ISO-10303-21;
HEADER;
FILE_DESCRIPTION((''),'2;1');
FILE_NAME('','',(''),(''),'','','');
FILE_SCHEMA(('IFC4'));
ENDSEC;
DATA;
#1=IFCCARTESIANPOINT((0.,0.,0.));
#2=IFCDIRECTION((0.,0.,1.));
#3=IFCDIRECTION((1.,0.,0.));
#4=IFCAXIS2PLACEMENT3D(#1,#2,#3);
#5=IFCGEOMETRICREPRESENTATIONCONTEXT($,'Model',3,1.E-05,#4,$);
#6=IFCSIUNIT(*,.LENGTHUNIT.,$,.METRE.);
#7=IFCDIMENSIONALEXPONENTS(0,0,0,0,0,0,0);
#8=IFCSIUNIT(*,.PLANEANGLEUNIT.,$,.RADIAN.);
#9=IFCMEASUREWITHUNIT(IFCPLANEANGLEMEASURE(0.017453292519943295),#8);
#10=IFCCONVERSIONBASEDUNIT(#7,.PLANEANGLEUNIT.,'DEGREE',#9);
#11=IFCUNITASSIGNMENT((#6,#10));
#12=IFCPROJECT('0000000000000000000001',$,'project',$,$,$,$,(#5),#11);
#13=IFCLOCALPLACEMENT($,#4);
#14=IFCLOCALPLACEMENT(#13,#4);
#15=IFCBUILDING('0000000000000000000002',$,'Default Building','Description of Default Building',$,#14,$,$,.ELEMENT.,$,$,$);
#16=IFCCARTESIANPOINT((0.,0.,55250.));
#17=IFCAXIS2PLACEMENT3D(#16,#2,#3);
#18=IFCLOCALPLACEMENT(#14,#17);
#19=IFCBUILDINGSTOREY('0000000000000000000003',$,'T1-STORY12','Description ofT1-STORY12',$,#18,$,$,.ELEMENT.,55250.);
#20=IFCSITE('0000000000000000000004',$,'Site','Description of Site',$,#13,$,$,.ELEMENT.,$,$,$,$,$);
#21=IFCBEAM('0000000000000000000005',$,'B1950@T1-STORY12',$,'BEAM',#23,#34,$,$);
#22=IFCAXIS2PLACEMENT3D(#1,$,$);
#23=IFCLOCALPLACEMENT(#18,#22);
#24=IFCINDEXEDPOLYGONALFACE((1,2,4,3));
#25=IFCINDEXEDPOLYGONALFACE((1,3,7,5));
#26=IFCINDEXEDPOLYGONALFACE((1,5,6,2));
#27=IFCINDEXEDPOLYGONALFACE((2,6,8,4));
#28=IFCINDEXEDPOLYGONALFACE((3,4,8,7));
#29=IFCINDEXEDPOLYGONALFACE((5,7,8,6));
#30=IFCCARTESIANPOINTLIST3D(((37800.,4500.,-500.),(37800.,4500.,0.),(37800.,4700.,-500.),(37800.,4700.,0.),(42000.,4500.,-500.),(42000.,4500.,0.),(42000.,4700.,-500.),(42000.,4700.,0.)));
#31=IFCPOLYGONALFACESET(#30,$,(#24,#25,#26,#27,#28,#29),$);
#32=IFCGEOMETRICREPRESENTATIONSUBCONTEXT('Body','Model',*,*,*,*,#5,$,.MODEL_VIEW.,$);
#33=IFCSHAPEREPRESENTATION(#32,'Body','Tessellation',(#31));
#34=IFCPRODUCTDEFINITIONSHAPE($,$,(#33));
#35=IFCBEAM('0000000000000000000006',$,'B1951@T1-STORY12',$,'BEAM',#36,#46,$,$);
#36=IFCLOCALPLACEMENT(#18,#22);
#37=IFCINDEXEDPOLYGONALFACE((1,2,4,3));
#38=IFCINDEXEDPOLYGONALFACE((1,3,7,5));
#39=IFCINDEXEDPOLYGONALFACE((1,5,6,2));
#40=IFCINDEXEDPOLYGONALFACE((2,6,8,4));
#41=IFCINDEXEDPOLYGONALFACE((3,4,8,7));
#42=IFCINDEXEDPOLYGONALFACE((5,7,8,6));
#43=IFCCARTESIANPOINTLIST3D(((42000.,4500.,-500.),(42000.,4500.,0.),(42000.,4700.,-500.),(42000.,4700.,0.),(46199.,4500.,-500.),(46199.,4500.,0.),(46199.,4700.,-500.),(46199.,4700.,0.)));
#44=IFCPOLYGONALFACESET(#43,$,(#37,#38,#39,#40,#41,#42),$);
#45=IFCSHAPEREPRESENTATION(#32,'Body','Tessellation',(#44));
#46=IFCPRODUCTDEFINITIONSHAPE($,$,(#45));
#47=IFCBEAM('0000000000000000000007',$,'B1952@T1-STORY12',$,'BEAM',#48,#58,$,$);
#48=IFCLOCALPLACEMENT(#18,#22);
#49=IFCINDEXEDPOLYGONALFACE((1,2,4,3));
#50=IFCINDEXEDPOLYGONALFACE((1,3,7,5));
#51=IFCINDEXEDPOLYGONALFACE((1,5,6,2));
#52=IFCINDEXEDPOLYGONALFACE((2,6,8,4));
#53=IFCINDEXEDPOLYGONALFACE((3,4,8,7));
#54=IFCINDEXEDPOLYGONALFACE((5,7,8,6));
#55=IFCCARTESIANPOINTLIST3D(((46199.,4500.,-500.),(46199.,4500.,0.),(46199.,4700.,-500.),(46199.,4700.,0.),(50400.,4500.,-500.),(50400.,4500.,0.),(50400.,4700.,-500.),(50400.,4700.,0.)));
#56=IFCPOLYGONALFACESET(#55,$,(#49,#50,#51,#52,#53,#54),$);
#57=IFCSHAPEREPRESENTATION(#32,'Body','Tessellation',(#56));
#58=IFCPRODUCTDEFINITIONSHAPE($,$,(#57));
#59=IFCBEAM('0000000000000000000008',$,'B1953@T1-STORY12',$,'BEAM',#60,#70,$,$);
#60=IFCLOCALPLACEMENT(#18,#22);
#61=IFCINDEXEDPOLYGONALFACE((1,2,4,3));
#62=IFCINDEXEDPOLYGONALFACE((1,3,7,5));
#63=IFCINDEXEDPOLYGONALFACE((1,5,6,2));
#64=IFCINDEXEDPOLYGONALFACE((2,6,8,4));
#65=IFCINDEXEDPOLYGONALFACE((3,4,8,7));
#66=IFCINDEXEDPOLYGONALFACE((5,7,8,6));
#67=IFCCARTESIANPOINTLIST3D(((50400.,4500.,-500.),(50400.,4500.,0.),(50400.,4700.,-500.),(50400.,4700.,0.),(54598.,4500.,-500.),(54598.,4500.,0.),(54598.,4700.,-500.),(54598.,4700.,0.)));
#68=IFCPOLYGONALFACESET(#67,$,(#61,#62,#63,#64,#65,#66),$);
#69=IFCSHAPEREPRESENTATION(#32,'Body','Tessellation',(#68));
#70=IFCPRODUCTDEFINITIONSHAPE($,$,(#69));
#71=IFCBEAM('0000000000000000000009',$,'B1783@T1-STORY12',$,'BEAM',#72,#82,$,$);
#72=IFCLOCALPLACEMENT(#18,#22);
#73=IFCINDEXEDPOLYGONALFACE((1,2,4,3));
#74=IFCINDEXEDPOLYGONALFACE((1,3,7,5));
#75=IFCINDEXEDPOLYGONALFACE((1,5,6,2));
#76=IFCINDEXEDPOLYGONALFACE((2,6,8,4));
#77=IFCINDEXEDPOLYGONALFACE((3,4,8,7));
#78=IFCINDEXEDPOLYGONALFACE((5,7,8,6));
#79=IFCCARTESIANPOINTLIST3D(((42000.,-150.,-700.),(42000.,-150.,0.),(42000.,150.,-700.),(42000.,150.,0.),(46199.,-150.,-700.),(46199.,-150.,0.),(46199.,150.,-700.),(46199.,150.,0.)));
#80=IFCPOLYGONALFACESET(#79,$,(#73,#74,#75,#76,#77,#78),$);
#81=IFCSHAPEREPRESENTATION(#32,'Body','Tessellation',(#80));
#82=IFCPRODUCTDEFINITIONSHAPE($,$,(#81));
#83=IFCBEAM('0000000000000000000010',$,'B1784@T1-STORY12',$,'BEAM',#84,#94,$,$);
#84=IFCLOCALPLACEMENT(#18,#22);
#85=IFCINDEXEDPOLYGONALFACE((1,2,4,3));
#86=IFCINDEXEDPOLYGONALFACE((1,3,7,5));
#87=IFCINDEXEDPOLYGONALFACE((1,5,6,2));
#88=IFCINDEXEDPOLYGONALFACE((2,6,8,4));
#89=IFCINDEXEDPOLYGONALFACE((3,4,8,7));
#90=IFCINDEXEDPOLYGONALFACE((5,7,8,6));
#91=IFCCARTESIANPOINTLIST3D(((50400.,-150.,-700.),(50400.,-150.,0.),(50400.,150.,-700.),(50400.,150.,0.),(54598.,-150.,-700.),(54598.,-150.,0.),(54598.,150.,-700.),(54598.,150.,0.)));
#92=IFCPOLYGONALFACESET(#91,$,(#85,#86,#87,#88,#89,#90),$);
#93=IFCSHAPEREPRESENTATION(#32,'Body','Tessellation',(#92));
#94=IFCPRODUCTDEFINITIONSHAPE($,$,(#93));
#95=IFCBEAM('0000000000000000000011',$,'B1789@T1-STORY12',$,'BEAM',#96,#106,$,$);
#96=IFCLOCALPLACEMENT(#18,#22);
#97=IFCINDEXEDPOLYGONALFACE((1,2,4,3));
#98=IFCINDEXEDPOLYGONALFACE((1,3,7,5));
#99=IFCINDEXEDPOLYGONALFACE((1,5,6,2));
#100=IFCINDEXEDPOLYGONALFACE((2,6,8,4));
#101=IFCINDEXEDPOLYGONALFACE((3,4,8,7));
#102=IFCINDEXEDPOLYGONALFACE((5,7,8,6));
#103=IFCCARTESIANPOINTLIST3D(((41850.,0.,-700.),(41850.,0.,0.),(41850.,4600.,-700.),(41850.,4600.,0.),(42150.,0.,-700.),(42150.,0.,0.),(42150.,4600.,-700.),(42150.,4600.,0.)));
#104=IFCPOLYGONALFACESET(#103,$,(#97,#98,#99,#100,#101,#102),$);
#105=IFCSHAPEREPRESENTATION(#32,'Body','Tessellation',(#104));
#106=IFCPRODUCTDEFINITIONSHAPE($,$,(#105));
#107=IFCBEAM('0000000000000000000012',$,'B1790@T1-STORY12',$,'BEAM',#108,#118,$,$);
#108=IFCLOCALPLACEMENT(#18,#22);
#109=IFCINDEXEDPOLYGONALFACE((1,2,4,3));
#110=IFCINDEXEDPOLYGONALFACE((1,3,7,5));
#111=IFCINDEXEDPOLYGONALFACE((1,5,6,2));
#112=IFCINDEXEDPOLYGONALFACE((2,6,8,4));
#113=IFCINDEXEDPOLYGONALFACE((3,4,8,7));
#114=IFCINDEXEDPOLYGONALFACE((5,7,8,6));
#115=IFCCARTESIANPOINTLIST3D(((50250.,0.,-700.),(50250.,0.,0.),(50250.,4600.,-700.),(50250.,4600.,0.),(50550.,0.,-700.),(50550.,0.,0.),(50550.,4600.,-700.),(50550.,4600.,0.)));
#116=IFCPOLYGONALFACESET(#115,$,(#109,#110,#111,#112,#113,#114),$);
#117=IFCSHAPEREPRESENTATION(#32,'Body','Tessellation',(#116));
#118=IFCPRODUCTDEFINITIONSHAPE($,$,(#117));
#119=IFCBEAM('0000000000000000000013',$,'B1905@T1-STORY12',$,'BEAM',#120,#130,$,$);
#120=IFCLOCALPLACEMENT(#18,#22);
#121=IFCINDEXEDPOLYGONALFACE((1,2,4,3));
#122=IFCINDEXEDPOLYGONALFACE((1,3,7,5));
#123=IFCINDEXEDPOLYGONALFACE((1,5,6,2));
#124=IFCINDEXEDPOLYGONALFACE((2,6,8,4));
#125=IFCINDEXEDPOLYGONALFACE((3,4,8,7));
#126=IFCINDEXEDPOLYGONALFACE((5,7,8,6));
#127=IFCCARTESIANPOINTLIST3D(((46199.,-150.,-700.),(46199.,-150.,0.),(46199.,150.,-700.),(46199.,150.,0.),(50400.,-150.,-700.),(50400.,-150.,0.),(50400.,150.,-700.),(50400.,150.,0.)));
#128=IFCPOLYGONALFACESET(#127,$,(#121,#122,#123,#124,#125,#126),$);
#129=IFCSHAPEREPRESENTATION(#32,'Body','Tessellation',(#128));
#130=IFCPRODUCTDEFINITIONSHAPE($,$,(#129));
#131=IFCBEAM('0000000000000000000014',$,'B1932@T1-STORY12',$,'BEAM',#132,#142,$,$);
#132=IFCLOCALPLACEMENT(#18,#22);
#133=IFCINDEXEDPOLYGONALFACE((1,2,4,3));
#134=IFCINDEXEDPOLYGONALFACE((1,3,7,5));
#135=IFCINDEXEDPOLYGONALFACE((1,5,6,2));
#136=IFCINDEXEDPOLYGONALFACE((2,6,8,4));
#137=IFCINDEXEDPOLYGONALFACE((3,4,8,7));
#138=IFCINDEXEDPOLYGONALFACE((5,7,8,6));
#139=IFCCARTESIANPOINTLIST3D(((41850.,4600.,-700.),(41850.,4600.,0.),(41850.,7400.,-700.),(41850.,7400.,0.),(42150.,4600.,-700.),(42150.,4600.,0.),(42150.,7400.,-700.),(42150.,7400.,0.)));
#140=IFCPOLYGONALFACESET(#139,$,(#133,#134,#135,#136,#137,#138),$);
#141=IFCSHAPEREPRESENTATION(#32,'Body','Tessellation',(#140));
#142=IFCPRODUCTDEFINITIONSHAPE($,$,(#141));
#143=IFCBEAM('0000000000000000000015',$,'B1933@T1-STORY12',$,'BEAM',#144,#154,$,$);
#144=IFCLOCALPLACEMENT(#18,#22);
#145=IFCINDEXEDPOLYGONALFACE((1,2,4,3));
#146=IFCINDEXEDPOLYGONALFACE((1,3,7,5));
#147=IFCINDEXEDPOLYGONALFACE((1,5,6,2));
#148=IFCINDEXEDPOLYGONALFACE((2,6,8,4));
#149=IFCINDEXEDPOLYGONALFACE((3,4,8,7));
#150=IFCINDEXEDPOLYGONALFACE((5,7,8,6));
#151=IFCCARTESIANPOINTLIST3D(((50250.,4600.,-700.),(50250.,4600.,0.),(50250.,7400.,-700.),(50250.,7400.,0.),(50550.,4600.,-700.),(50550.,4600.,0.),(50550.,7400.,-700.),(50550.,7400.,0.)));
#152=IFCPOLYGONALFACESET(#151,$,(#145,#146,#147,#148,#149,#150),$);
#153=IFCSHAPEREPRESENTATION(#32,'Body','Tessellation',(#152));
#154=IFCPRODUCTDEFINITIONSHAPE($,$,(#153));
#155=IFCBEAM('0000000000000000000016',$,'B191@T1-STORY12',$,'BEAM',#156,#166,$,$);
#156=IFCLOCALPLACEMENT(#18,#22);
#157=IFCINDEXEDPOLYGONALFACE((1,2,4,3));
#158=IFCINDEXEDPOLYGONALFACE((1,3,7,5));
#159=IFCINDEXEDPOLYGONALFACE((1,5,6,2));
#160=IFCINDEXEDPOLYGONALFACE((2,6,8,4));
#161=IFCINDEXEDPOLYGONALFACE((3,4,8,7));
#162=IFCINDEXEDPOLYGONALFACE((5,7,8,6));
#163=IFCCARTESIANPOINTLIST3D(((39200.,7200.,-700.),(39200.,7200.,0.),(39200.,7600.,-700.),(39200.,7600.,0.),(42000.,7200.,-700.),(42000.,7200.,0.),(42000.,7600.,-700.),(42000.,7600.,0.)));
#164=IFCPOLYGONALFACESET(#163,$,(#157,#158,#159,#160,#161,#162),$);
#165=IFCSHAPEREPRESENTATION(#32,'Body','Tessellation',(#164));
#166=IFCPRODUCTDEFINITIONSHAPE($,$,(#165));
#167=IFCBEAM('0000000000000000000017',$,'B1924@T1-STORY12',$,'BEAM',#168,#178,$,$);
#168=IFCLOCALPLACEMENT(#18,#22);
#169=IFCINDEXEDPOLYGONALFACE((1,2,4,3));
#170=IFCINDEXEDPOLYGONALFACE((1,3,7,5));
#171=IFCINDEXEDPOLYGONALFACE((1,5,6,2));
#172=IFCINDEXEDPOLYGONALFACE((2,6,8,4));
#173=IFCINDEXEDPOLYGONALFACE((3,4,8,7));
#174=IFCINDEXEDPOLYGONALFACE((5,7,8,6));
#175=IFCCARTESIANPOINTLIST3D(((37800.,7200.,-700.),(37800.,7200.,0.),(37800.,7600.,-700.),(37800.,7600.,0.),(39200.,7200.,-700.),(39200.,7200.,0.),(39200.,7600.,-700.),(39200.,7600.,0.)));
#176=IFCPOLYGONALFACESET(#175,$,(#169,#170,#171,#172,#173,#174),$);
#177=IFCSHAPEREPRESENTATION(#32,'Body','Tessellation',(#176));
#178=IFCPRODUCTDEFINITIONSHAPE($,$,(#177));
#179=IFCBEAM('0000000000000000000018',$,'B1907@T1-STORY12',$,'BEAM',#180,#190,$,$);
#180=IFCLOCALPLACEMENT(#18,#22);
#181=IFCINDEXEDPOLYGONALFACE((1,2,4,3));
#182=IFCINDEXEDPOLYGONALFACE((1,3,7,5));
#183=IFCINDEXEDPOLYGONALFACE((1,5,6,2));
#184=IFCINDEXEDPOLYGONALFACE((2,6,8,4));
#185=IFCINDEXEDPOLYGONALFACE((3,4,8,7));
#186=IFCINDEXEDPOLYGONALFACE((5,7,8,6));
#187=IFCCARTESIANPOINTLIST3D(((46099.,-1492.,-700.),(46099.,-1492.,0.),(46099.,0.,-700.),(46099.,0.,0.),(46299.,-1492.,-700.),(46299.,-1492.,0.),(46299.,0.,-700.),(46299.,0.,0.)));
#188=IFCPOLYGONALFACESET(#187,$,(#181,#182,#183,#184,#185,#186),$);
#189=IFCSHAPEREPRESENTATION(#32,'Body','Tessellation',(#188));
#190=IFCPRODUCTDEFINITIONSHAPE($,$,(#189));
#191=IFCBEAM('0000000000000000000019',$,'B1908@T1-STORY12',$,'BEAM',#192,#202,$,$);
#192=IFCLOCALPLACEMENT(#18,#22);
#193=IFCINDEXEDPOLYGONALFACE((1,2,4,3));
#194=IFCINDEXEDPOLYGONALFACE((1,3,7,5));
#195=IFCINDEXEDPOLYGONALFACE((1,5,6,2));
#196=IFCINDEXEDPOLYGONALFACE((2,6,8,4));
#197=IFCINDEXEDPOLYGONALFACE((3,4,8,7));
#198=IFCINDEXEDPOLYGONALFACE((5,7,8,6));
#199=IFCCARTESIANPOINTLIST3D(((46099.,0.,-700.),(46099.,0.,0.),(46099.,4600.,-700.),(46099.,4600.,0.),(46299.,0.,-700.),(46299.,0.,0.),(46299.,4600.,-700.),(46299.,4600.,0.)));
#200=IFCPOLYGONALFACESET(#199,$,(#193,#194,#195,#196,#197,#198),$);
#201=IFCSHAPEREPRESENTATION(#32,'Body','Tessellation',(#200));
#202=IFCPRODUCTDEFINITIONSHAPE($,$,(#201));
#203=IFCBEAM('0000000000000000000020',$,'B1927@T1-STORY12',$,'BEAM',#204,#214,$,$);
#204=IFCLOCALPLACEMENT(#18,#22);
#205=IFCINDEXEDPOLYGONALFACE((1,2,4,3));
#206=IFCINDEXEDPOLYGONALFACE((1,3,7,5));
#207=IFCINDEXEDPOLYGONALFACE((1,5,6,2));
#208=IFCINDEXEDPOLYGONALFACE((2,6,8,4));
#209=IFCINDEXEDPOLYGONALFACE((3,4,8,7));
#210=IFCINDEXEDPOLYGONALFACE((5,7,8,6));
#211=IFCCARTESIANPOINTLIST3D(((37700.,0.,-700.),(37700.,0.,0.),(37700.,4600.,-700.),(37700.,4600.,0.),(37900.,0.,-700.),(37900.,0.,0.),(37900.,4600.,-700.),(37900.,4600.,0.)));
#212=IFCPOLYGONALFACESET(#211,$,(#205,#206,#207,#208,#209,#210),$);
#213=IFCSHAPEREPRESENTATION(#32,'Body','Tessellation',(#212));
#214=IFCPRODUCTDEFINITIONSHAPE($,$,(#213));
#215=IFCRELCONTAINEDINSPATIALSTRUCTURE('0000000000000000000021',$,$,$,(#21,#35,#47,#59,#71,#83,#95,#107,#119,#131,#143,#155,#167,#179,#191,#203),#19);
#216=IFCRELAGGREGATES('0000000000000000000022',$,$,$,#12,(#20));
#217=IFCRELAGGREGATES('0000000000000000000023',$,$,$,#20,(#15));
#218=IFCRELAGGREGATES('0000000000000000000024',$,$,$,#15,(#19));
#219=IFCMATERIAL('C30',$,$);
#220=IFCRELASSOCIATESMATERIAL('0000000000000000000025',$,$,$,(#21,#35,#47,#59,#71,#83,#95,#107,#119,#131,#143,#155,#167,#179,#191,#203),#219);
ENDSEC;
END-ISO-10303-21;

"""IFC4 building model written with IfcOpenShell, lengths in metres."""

from ifc_helpers import new_model, entity, si_unit, converted_unit, frame, origin_with_axes, place, context, subcontext, project, spatial, rectangle, extrude, material, element, save


model = new_model("IFC4")

# Units and contexts
model_context = context("Model", 3, precision=1e-05, world=origin_with_axes())
body_context = subcontext(model_context, "Body", "Model", "MODEL_VIEW")
ifc_project = project(units=[si_unit("LENGTHUNIT", "METRE"), converted_unit("PLANEANGLEUNIT", "DEGREE", entity("IfcPlaneAngleMeasure", 0.017453292519943295), si_unit("PLANEANGLEUNIT", "RADIAN"), dimensions=[0, 0, 0, 0, 0, 0, 0])], contexts=[model_context])

# Site, building, storey
site_placement = place(None, origin_with_axes())
site = spatial("IfcSite", under=ifc_project, at=site_placement, Name="Site", Description="Description of Site", CompositionType="ELEMENT")
building_placement = place(site_placement, origin_with_axes())
building = spatial("IfcBuilding", under=site, at=building_placement, Name="Default Building", Description="Description of Default Building", CompositionType="ELEMENT")
storey_placement = place(building_placement, frame((0.0, 0.0, 55250.0), z_axis=(0.0, 0.0, 1.0), x_axis=(1.0, 0.0, 0.0)))
storey = spatial("IfcBuildingStorey", under=building, at=storey_placement, Name="T1-STORY12", Description="Description ofT1-STORY12", CompositionType="ELEMENT", Elevation=55250.0)

# Beams
ifc_material_1 = material(Name="C30")
beam_1_placement = place(storey_placement, frame((37800.0, 4600.0, -250.0), z_axis=(1.0, 0.0, 0.0), x_axis=(0.0, 1.0, 0.0)))
element("IfcBeam", 1, at=beam_1_placement, inside=storey, material=ifc_material_1, Name="B1950@T1-STORY12", ObjectType="BEAM", context=body_context, shape_type="SweptSolid", body=[
    extrude(rectangle(XDim=200.0, YDim=500.0), origin_with_axes(), (0.0, 0.0, 1.0), 4200.0),
])
beam_2_placement = place(storey_placement, frame((42000.0, 4600.0, -250.0), z_axis=(1.0, 0.0, 0.0), x_axis=(0.0, 1.0, 0.0)))
element("IfcBeam", 2, at=beam_2_placement, inside=storey, material=ifc_material_1, Name="B1951@T1-STORY12", ObjectType="BEAM", context=body_context, shape_type="SweptSolid", body=[
    extrude(rectangle(XDim=200.0, YDim=500.0), origin_with_axes(), (0.0, 0.0, 1.0), 4199.0),
])
beam_3_placement = place(storey_placement, frame((46199.0, 4600.0, -250.0), z_axis=(1.0, 0.0, 0.0), x_axis=(0.0, 1.0, 0.0)))
element("IfcBeam", 3, at=beam_3_placement, inside=storey, material=ifc_material_1, Name="B1952@T1-STORY12", ObjectType="BEAM", context=body_context, shape_type="SweptSolid", body=[
    extrude(rectangle(XDim=200.0, YDim=500.0), origin_with_axes(), (0.0, 0.0, 1.0), 4201.0),
])
beam_4_placement = place(storey_placement, frame((50400.0, 4600.0, -250.0), z_axis=(1.0, 0.0, 0.0), x_axis=(0.0, 1.0, 0.0)))
element("IfcBeam", 4, at=beam_4_placement, inside=storey, material=ifc_material_1, Name="B1953@T1-STORY12", ObjectType="BEAM", context=body_context, shape_type="SweptSolid", body=[
    extrude(rectangle(XDim=200.0, YDim=500.0), origin_with_axes(), (0.0, 0.0, 1.0), 4198.0),
])
beam_5_placement = place(storey_placement, frame((42000.0, 0.0, -350.0), z_axis=(1.0, 0.0, 0.0), x_axis=(0.0, 1.0, 0.0)))
element("IfcBeam", 5, at=beam_5_placement, inside=storey, material=ifc_material_1, Name="B1783@T1-STORY12", ObjectType="BEAM", context=body_context, shape_type="SweptSolid", body=[
    extrude(rectangle(XDim=300.0, YDim=700.0), origin_with_axes(), (0.0, 0.0, 1.0), 4199.0),
])
beam_6_placement = place(storey_placement, frame((50400.0, 0.0, -350.0), z_axis=(1.0, 0.0, 0.0), x_axis=(0.0, 1.0, 0.0)))
element("IfcBeam", 6, at=beam_6_placement, inside=storey, material=ifc_material_1, Name="B1784@T1-STORY12", ObjectType="BEAM", context=body_context, shape_type="SweptSolid", body=[
    extrude(rectangle(XDim=300.0, YDim=700.0), origin_with_axes(), (0.0, 0.0, 1.0), 4198.0),
])
for number, where, z_axis, x_axis, name in (
    (7, (42000.0, 0.0, -350.0), (0.0, 1.0, 0.0), (-1.0, 0.0, 0.0), "B1789@T1-STORY12"),
    (8, (50400.0, 0.0, -350.0), (0.0, 1.0, 0.0), (-1.0, 0.0, 0.0), "B1790@T1-STORY12"),
):
    element("IfcBeam", number, at=place(storey_placement, frame(where, z_axis=z_axis, x_axis=x_axis)), inside=storey, material=ifc_material_1, Name=name, ObjectType="BEAM", context=body_context, shape_type="SweptSolid", body=[
        extrude(rectangle(XDim=300.0, YDim=700.0), origin_with_axes(), (0.0, 0.0, 1.0), 4600.0),
    ])
beam_7_placement = place(storey_placement, frame((46199.0, 0.0, -350.0), z_axis=(1.0, 0.0, 0.0), x_axis=(0.0, 1.0, 0.0)))
element("IfcBeam", 9, at=beam_7_placement, inside=storey, material=ifc_material_1, Name="B1905@T1-STORY12", ObjectType="BEAM", context=body_context, shape_type="SweptSolid", body=[
    extrude(rectangle(XDim=300.0, YDim=700.0), origin_with_axes(), (0.0, 0.0, 1.0), 4201.0),
])
for number, where, z_axis, x_axis, name in (
    (10, (42000.0, 4600.0, -350.0), (0.0, 1.0, 0.0), (-1.0, 0.0, 0.0), "B1932@T1-STORY12"),
    (11, (50400.0, 4600.0, -350.0), (0.0, 1.0, 0.0), (-1.0, 0.0, 0.0), "B1933@T1-STORY12"),
):
    element("IfcBeam", number, at=place(storey_placement, frame(where, z_axis=z_axis, x_axis=x_axis)), inside=storey, material=ifc_material_1, Name=name, ObjectType="BEAM", context=body_context, shape_type="SweptSolid", body=[
        extrude(rectangle(XDim=300.0, YDim=700.0), origin_with_axes(), (0.0, 0.0, 1.0), 2800.0),
    ])
beam_8_placement = place(storey_placement, frame((39200.0, 7400.0, -350.0), z_axis=(1.0, 0.0, 0.0), x_axis=(0.0, 1.0, 0.0)))
element("IfcBeam", 12, at=beam_8_placement, inside=storey, material=ifc_material_1, Name="B191@T1-STORY12", ObjectType="BEAM", context=body_context, shape_type="SweptSolid", body=[
    extrude(rectangle(XDim=400.0, YDim=700.0), origin_with_axes(), (0.0, 0.0, 1.0), 2800.0),
])
beam_9_placement = place(storey_placement, frame((37800.0, 7400.0, -350.0), z_axis=(1.0, 0.0, 0.0), x_axis=(0.0, 1.0, 0.0)))
element("IfcBeam", 13, at=beam_9_placement, inside=storey, material=ifc_material_1, Name="B1924@T1-STORY12", ObjectType="BEAM", context=body_context, shape_type="SweptSolid", body=[
    extrude(rectangle(XDim=400.0, YDim=700.0), origin_with_axes(), (0.0, 0.0, 1.0), 1400.0),
])
beam_10_placement = place(storey_placement, frame((46199.0, -1492.0, -350.0), z_axis=(0.0, 1.0, 0.0), x_axis=(-1.0, 0.0, 0.0)))
element("IfcBeam", 14, at=beam_10_placement, inside=storey, material=ifc_material_1, Name="B1907@T1-STORY12", ObjectType="BEAM", context=body_context, shape_type="SweptSolid", body=[
    extrude(rectangle(XDim=200.0, YDim=700.0), origin_with_axes(), (0.0, 0.0, 1.0), 1492.0),
])
for number, where, z_axis, x_axis, name in (
    (15, (46199.0, 0.0, -350.0), (0.0, 1.0, 0.0), (-1.0, 0.0, 0.0), "B1908@T1-STORY12"),
    (16, (37800.0, 0.0, -350.0), (0.0, 1.0, 0.0), (-1.0, 0.0, 0.0), "B1927@T1-STORY12"),
):
    element("IfcBeam", number, at=place(storey_placement, frame(where, z_axis=z_axis, x_axis=x_axis)), inside=storey, material=ifc_material_1, Name=name, ObjectType="BEAM", context=body_context, shape_type="SweptSolid", body=[
        extrude(rectangle(XDim=200.0, YDim=700.0), origin_with_axes(), (0.0, 0.0, 1.0), 4600.0),
    ])

save(model, "model.ifc")
